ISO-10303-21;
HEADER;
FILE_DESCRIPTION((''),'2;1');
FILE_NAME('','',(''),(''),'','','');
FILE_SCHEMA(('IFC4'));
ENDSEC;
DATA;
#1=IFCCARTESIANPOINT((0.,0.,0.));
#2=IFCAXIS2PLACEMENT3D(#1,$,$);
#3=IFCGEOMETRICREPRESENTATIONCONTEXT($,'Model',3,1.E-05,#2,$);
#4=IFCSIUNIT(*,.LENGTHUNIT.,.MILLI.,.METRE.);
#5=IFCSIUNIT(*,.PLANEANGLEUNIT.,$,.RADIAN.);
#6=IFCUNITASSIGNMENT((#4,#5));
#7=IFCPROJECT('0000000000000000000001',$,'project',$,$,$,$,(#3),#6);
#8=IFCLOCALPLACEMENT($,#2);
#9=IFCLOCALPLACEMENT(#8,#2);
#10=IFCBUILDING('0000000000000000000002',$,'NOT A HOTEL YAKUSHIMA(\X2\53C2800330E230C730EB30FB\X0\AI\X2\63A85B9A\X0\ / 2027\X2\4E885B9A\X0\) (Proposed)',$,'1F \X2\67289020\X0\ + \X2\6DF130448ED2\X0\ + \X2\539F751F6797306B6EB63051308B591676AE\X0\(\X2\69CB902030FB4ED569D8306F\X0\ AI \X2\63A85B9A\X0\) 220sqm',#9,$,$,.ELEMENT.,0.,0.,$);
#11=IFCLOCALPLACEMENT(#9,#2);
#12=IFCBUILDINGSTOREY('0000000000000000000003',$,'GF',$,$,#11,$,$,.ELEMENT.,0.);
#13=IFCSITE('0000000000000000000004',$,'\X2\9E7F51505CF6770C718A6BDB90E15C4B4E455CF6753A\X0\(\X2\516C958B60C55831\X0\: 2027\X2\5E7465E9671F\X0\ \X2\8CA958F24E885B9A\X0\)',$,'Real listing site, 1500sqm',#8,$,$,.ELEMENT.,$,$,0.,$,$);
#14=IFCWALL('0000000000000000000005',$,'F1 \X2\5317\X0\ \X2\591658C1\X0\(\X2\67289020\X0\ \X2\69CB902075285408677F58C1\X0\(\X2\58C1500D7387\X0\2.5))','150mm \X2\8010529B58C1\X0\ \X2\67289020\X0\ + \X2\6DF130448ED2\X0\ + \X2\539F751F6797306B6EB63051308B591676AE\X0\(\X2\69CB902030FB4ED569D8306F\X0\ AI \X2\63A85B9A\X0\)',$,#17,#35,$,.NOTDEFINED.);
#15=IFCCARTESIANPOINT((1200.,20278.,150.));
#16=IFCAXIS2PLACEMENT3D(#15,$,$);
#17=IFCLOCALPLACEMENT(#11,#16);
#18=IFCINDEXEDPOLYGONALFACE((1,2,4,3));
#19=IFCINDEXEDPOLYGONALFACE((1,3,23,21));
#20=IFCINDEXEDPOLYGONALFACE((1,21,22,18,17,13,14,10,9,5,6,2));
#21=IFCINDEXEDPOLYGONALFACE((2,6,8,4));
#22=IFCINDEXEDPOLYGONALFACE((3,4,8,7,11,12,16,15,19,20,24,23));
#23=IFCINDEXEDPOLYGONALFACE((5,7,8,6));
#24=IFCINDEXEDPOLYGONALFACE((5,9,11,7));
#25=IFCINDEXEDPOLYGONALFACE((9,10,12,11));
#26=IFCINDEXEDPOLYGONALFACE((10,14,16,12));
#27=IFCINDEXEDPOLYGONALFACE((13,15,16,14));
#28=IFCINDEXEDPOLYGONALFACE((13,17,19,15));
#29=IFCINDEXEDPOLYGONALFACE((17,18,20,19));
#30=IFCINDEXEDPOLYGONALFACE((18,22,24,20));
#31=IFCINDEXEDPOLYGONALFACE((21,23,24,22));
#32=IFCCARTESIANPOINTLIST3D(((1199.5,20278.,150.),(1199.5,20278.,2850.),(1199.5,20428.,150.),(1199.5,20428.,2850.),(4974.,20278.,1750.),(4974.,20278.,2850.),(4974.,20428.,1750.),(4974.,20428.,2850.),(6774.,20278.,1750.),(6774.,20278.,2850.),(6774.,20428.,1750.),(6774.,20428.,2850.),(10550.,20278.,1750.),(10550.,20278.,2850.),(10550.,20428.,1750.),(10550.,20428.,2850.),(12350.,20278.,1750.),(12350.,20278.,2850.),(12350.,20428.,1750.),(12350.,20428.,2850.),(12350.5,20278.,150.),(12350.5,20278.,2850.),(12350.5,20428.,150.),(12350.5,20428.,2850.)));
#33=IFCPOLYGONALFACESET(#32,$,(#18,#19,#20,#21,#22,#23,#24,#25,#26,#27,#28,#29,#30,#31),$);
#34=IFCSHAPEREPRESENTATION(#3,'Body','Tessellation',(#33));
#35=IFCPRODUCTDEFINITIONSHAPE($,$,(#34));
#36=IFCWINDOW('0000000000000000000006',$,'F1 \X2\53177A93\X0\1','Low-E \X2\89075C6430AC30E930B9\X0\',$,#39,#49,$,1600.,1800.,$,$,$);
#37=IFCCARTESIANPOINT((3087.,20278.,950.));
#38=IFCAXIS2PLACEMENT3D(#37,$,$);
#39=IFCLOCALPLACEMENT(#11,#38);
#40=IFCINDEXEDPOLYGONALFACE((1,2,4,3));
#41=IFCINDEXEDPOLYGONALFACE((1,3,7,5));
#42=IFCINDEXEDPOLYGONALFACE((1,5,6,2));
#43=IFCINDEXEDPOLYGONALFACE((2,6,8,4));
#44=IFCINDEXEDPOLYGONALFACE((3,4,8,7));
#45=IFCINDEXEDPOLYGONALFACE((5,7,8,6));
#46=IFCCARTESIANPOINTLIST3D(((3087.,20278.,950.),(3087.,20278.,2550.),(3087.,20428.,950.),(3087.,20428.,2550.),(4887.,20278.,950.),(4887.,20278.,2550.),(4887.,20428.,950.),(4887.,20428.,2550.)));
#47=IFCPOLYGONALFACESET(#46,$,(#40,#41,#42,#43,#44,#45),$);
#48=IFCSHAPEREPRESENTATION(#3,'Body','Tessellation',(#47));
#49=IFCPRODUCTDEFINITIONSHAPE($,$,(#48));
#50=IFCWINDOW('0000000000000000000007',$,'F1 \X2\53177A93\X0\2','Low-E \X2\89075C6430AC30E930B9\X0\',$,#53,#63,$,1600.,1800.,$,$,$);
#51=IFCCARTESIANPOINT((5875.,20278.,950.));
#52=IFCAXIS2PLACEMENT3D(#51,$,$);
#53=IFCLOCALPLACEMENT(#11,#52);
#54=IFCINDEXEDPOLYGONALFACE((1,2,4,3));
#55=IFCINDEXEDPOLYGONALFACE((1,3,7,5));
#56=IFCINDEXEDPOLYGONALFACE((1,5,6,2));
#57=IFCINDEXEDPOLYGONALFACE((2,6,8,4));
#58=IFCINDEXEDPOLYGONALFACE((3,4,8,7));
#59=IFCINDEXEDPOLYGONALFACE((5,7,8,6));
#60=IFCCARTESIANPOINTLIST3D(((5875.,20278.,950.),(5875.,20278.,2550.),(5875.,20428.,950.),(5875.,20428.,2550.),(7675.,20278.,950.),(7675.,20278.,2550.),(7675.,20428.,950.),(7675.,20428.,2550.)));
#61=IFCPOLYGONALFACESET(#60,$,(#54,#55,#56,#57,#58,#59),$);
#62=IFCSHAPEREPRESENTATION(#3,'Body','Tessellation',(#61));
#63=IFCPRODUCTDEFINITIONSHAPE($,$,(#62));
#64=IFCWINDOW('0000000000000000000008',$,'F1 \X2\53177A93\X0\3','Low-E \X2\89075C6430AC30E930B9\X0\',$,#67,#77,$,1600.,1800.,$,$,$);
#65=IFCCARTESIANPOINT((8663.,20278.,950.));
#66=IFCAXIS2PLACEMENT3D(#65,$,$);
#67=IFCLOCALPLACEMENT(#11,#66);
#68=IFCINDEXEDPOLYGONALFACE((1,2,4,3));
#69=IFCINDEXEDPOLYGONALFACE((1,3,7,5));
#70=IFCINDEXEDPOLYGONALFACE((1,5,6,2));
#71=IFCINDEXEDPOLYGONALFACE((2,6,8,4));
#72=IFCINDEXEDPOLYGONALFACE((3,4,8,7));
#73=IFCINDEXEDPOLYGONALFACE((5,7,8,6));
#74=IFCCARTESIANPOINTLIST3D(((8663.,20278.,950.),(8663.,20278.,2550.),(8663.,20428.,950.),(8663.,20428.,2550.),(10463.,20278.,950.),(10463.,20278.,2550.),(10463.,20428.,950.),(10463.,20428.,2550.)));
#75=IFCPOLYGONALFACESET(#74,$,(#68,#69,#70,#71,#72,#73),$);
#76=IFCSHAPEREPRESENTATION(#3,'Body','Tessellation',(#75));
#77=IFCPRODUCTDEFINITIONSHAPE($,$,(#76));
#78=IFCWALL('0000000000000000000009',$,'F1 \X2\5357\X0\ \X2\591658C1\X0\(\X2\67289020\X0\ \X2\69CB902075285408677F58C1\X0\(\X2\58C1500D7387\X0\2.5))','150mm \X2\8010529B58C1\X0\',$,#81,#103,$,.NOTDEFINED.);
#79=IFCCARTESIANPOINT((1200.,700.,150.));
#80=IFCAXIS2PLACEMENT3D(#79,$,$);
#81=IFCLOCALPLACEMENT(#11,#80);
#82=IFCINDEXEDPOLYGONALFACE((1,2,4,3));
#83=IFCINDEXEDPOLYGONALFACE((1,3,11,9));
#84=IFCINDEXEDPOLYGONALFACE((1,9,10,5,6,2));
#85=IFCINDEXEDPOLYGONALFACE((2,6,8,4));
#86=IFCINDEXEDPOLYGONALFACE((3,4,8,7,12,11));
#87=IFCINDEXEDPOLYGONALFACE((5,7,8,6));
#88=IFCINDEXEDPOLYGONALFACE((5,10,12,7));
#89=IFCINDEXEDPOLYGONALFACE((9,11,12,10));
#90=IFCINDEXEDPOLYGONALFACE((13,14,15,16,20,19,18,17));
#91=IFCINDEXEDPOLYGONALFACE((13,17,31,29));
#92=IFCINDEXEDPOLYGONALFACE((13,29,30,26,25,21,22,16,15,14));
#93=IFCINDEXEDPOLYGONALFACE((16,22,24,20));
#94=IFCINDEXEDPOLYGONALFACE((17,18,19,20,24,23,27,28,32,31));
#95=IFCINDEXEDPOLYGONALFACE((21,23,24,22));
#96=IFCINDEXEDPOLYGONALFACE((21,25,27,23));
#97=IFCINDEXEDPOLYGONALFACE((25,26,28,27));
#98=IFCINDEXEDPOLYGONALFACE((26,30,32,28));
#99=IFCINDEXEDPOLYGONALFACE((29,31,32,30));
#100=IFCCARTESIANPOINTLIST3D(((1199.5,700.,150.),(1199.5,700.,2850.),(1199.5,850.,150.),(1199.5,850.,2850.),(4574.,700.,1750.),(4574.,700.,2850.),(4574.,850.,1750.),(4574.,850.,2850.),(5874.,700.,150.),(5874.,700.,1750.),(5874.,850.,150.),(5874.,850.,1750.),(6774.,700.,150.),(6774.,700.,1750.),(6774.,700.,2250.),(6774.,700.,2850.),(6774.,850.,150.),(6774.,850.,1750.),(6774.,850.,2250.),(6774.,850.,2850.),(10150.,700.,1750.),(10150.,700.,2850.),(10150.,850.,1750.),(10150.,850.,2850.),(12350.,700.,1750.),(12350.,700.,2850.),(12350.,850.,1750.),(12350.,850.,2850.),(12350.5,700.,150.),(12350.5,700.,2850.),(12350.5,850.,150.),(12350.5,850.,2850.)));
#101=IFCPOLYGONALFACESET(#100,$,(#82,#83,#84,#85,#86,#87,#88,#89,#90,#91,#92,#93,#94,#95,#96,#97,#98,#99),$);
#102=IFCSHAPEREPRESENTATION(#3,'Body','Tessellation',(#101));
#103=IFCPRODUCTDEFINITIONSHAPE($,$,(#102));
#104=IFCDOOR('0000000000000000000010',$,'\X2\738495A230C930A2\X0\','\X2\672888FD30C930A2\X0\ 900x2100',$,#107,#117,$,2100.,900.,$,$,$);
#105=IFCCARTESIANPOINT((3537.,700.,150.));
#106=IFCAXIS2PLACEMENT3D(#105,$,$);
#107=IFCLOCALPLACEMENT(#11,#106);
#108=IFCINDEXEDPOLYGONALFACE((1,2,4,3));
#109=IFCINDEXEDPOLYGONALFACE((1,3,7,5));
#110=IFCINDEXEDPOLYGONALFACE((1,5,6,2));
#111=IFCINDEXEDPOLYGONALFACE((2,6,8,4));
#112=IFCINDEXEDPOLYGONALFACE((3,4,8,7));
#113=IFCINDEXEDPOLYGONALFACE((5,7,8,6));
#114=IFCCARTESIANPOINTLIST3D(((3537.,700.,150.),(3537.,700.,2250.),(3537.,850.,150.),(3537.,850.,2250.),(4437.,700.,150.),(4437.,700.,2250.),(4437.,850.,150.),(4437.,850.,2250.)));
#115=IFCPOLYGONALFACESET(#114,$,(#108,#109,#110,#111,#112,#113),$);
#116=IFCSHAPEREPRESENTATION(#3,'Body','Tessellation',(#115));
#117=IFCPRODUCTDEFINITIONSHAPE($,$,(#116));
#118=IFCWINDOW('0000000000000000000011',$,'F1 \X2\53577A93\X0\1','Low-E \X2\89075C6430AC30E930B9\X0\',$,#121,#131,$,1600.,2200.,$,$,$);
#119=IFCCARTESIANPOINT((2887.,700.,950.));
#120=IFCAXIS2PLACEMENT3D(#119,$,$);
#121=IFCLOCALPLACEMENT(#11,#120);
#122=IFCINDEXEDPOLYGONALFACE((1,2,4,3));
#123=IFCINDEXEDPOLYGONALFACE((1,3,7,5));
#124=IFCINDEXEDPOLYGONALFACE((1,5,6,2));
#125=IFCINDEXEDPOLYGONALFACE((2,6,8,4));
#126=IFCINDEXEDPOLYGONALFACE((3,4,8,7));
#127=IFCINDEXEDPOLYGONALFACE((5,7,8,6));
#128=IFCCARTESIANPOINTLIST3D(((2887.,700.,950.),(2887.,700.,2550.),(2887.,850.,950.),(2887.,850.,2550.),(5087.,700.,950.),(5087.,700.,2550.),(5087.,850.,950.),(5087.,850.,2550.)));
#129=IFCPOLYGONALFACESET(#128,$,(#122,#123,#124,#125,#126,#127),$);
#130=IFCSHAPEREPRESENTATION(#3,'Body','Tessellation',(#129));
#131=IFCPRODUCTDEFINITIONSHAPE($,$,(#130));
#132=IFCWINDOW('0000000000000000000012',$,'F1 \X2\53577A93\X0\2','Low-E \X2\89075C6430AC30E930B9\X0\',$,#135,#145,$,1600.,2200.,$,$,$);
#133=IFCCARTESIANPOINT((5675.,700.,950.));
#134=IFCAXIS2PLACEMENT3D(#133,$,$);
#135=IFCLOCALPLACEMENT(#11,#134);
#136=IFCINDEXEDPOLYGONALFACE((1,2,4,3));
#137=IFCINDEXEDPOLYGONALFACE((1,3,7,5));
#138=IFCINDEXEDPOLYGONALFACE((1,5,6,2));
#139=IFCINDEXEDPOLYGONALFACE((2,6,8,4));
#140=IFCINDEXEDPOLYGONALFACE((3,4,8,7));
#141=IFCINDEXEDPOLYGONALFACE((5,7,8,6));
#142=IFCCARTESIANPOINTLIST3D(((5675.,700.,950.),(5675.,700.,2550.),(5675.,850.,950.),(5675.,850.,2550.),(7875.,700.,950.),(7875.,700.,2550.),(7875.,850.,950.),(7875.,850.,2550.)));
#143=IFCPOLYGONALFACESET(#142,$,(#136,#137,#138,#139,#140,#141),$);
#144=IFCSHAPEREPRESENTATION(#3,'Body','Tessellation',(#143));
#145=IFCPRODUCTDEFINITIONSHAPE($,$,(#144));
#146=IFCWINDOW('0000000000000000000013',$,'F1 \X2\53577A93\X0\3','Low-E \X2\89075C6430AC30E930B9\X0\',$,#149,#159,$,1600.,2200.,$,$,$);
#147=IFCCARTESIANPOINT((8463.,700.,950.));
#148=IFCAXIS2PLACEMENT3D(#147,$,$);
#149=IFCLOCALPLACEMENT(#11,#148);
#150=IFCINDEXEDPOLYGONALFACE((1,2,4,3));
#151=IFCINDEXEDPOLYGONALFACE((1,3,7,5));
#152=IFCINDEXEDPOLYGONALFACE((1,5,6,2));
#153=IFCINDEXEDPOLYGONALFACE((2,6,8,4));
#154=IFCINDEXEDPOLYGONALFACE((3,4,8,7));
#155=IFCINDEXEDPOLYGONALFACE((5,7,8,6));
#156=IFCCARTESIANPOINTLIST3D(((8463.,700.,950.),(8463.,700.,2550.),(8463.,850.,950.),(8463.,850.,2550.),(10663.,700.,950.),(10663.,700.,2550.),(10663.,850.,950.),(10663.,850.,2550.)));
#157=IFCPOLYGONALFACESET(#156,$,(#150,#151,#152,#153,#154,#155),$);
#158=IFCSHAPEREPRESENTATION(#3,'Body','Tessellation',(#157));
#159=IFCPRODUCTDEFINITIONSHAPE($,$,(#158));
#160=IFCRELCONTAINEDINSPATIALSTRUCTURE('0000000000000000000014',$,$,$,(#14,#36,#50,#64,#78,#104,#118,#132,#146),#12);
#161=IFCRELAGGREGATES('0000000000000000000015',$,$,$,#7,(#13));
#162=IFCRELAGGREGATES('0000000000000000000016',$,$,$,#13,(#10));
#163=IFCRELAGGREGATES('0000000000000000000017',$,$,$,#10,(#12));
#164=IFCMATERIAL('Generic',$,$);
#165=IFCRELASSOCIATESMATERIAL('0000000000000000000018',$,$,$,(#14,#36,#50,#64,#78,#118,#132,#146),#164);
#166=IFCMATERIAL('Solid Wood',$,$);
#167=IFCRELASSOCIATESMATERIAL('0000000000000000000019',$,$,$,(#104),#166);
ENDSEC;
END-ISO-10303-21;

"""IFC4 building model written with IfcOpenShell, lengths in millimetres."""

from ifc_helpers import new_model, si_unit, frame, frame_2d, origin, place, context, project, spatial, rectangle, extrude, material, element, fill, save


model = new_model("IFC4")

# Units and contexts
model_context = context("Model", 3, precision=1e-05, world=origin())
ifc_project = project(units=[si_unit("LENGTHUNIT", "METRE", prefix="MILLI"), si_unit("PLANEANGLEUNIT", "RADIAN")], contexts=[model_context])

# Site, building, storey
site_placement = place(None, origin())
site = spatial("IfcSite", under=ifc_project, at=site_placement, Name="鹿児島県熊毛郡屋久島町(公開情報: 2027年早期 販売予定)", ObjectType="Real listing site, 1500sqm", CompositionType="ELEMENT", RefElevation=0.0)
building_placement = place(site_placement, origin())
building = spatial("IfcBuilding", under=site, at=building_placement, Name="NOT A HOTEL YAKUSHIMA(参考モデル・AI推定 / 2027予定) (Proposed)", ObjectType="1F 木造 + 深い軒 + 原生林に溶ける外皮(構造・仕様は AI 推定) 220sqm", CompositionType="ELEMENT", ElevationOfRefHeight=0.0, ElevationOfTerrain=0.0)
storey_placement = place(building_placement, origin())
storey = spatial("IfcBuildingStorey", under=building, at=storey_placement, Name="GF", CompositionType="ELEMENT", Elevation=0.0)

# Shared definitions
ifc_material_1 = material(Name="Generic")

# Wall, openings, windows
wall_1_placement = place(storey_placement, frame((1200.0, 20278.0, 150.0)))
wall_1 = element("IfcWall", 1, at=wall_1_placement, inside=storey, material=ifc_material_1, Name="F1 北 外壁(木造 構造用合板壁(壁倍率2.5))", Description="150mm 耐力壁 木造 + 深い軒 + 原生林に溶ける外皮(構造・仕様は AI 推定)", PredefinedType="NOTDEFINED", context=model_context, shape_type="SweptSolid", body=[
    extrude(rectangle(XDim=11151.0, YDim=150.0, at=frame_2d((5575.0, 75.0))), frame((1200.0, 20278.0, 150.0)), (0.0, 0.0, 1.0), 2700.0),
])
opening_1_placement = place(storey_placement, frame((3087.0, 20278.0, 950.0)))
opening_1 = element("IfcOpeningElement", 2, at=opening_1_placement, cuts=wall_1, PredefinedType="NOTDEFINED", context=model_context, shape_type="SweptSolid", body=[
    extrude(rectangle(XDim=1800.0, YDim=150.0, at=frame_2d((900.0, 75.0))), frame((3087.0, 20278.0, 950.0)), (0.0, 0.0, 1.0), 1600.0),
])
opening_2_placement = place(storey_placement, frame((5875.0, 20278.0, 950.0)))
opening_2 = element("IfcOpeningElement", 3, at=opening_2_placement, cuts=wall_1, PredefinedType="NOTDEFINED", context=model_context, shape_type="SweptSolid", body=[
    extrude(rectangle(XDim=1800.0, YDim=150.0, at=frame_2d((900.0, 75.0))), frame((5875.0, 20278.0, 950.0)), (0.0, 0.0, 1.0), 1600.0),
])
opening_3_placement = place(storey_placement, frame((8663.0, 20278.0, 950.0)))
opening_3 = element("IfcOpeningElement", 4, at=opening_3_placement, cuts=wall_1, PredefinedType="NOTDEFINED", context=model_context, shape_type="SweptSolid", body=[
    extrude(rectangle(XDim=1800.0, YDim=150.0, at=frame_2d((900.0, 75.0))), frame((8663.0, 20278.0, 950.0)), (0.0, 0.0, 1.0), 1600.0),
])
window_1_placement = place(storey_placement, frame((3087.0, 20278.0, 950.0)))
window_1 = element("IfcWindow", 5, at=window_1_placement, inside=storey, material=ifc_material_1, Name="F1 北窓1", Description="Low-E 複層ガラス", OverallHeight=1600.0, OverallWidth=1800.0, context=model_context, shape_type="SweptSolid", body=[
    extrude(rectangle(XDim=1800.0, YDim=150.0, at=frame_2d((900.0, 75.0))), frame((3087.0, 20278.0, 950.0)), (0.0, 0.0, 1.0), 1600.0),
])
fill(opening_1, window_1)
window_2_placement = place(storey_placement, frame((5875.0, 20278.0, 950.0)))
window_2 = element("IfcWindow", 6, at=window_2_placement, inside=storey, material=ifc_material_1, Name="F1 北窓2", Description="Low-E 複層ガラス", OverallHeight=1600.0, OverallWidth=1800.0, context=model_context, shape_type="SweptSolid", body=[
    extrude(rectangle(XDim=1800.0, YDim=150.0, at=frame_2d((900.0, 75.0))), frame((5875.0, 20278.0, 950.0)), (0.0, 0.0, 1.0), 1600.0),
])
fill(opening_2, window_2)
window_3_placement = place(storey_placement, frame((8663.0, 20278.0, 950.0)))
window_3 = element("IfcWindow", 7, at=window_3_placement, inside=storey, material=ifc_material_1, Name="F1 北窓3", Description="Low-E 複層ガラス", OverallHeight=1600.0, OverallWidth=1800.0, context=model_context, shape_type="SweptSolid", body=[
    extrude(rectangle(XDim=1800.0, YDim=150.0, at=frame_2d((900.0, 75.0))), frame((8663.0, 20278.0, 950.0)), (0.0, 0.0, 1.0), 1600.0),
])
fill(opening_3, window_3)

# Wall, openings, door, windows
wall_2_placement = place(storey_placement, frame((1200.0, 700.0, 150.0)))
wall_2 = element("IfcWall", 8, at=wall_2_placement, inside=storey, material=ifc_material_1, Name="F1 南 外壁(木造 構造用合板壁(壁倍率2.5))", Description="150mm 耐力壁", PredefinedType="NOTDEFINED", context=model_context, shape_type="SweptSolid", body=[
    extrude(rectangle(XDim=11151.0, YDim=150.0, at=frame_2d((5575.0, 75.0))), frame((1200.0, 700.0, 150.0)), (0.0, 0.0, 1.0), 2700.0),
])
opening_4_placement = place(storey_placement, frame((3537.0, 700.0, 150.0)))
opening_4 = element("IfcOpeningElement", 9, at=opening_4_placement, cuts=wall_2, PredefinedType="NOTDEFINED", context=model_context, shape_type="SweptSolid", body=[
    extrude(rectangle(XDim=900.0, YDim=150.0, at=frame_2d((450.0, 75.0))), frame((3537.0, 700.0, 150.0)), (0.0, 0.0, 1.0), 2100.0),
])
opening_5_placement = place(storey_placement, frame((2887.0, 700.0, 950.0)))
opening_5 = element("IfcOpeningElement", 10, at=opening_5_placement, cuts=wall_2, PredefinedType="NOTDEFINED", context=model_context, shape_type="SweptSolid", body=[
    extrude(rectangle(XDim=2200.0, YDim=150.0, at=frame_2d((1100.0, 75.0))), frame((2887.0, 700.0, 950.0)), (0.0, 0.0, 1.0), 1600.0),
])
opening_6_placement = place(storey_placement, frame((5675.0, 700.0, 950.0)))
opening_6 = element("IfcOpeningElement", 11, at=opening_6_placement, cuts=wall_2, PredefinedType="NOTDEFINED", context=model_context, shape_type="SweptSolid", body=[
    extrude(rectangle(XDim=2200.0, YDim=150.0, at=frame_2d((1100.0, 75.0))), frame((5675.0, 700.0, 950.0)), (0.0, 0.0, 1.0), 1600.0),
])
opening_7_placement = place(storey_placement, frame((8463.0, 700.0, 950.0)))
opening_7 = element("IfcOpeningElement", 12, at=opening_7_placement, cuts=wall_2, PredefinedType="NOTDEFINED", context=model_context, shape_type="SweptSolid", body=[
    extrude(rectangle(XDim=2200.0, YDim=150.0, at=frame_2d((1100.0, 75.0))), frame((8463.0, 700.0, 950.0)), (0.0, 0.0, 1.0), 1600.0),
])
ifc_material_2 = material(Name="Solid Wood")
door_placement = place(storey_placement, frame((3537.0, 700.0, 150.0)))
door = element("IfcDoor", 13, at=door_placement, inside=storey, material=ifc_material_2, Name="玄関ドア", Description="木製ドア 900x2100", OverallHeight=2100.0, OverallWidth=900.0, context=model_context, shape_type="SweptSolid", body=[
    extrude(rectangle(XDim=900.0, YDim=150.0, at=frame_2d((450.0, 75.0))), frame((3537.0, 700.0, 150.0)), (0.0, 0.0, 1.0), 2100.0),
])
fill(opening_4, door)
window_4_placement = place(storey_placement, frame((2887.0, 700.0, 950.0)))
window_4 = element("IfcWindow", 14, at=window_4_placement, inside=storey, material=ifc_material_1, Name="F1 南窓1", Description="Low-E 複層ガラス", OverallHeight=1600.0, OverallWidth=2200.0, context=model_context, shape_type="SweptSolid", body=[
    extrude(rectangle(XDim=2200.0, YDim=150.0, at=frame_2d((1100.0, 75.0))), frame((2887.0, 700.0, 950.0)), (0.0, 0.0, 1.0), 1600.0),
])
fill(opening_5, window_4)
window_5_placement = place(storey_placement, frame((5675.0, 700.0, 950.0)))
window_5 = element("IfcWindow", 15, at=window_5_placement, inside=storey, material=ifc_material_1, Name="F1 南窓2", Description="Low-E 複層ガラス", OverallHeight=1600.0, OverallWidth=2200.0, context=model_context, shape_type="SweptSolid", body=[
    extrude(rectangle(XDim=2200.0, YDim=150.0, at=frame_2d((1100.0, 75.0))), frame((5675.0, 700.0, 950.0)), (0.0, 0.0, 1.0), 1600.0),
])
fill(opening_6, window_5)
window_6_placement = place(storey_placement, frame((8463.0, 700.0, 950.0)))
window_6 = element("IfcWindow", 16, at=window_6_placement, inside=storey, material=ifc_material_1, Name="F1 南窓3", Description="Low-E 複層ガラス", OverallHeight=1600.0, OverallWidth=2200.0, context=model_context, shape_type="SweptSolid", body=[
    extrude(rectangle(XDim=2200.0, YDim=150.0, at=frame_2d((1100.0, 75.0))), frame((8463.0, 700.0, 950.0)), (0.0, 0.0, 1.0), 1600.0),
])
fill(opening_7, window_6)

save(model, "model.ifc")
